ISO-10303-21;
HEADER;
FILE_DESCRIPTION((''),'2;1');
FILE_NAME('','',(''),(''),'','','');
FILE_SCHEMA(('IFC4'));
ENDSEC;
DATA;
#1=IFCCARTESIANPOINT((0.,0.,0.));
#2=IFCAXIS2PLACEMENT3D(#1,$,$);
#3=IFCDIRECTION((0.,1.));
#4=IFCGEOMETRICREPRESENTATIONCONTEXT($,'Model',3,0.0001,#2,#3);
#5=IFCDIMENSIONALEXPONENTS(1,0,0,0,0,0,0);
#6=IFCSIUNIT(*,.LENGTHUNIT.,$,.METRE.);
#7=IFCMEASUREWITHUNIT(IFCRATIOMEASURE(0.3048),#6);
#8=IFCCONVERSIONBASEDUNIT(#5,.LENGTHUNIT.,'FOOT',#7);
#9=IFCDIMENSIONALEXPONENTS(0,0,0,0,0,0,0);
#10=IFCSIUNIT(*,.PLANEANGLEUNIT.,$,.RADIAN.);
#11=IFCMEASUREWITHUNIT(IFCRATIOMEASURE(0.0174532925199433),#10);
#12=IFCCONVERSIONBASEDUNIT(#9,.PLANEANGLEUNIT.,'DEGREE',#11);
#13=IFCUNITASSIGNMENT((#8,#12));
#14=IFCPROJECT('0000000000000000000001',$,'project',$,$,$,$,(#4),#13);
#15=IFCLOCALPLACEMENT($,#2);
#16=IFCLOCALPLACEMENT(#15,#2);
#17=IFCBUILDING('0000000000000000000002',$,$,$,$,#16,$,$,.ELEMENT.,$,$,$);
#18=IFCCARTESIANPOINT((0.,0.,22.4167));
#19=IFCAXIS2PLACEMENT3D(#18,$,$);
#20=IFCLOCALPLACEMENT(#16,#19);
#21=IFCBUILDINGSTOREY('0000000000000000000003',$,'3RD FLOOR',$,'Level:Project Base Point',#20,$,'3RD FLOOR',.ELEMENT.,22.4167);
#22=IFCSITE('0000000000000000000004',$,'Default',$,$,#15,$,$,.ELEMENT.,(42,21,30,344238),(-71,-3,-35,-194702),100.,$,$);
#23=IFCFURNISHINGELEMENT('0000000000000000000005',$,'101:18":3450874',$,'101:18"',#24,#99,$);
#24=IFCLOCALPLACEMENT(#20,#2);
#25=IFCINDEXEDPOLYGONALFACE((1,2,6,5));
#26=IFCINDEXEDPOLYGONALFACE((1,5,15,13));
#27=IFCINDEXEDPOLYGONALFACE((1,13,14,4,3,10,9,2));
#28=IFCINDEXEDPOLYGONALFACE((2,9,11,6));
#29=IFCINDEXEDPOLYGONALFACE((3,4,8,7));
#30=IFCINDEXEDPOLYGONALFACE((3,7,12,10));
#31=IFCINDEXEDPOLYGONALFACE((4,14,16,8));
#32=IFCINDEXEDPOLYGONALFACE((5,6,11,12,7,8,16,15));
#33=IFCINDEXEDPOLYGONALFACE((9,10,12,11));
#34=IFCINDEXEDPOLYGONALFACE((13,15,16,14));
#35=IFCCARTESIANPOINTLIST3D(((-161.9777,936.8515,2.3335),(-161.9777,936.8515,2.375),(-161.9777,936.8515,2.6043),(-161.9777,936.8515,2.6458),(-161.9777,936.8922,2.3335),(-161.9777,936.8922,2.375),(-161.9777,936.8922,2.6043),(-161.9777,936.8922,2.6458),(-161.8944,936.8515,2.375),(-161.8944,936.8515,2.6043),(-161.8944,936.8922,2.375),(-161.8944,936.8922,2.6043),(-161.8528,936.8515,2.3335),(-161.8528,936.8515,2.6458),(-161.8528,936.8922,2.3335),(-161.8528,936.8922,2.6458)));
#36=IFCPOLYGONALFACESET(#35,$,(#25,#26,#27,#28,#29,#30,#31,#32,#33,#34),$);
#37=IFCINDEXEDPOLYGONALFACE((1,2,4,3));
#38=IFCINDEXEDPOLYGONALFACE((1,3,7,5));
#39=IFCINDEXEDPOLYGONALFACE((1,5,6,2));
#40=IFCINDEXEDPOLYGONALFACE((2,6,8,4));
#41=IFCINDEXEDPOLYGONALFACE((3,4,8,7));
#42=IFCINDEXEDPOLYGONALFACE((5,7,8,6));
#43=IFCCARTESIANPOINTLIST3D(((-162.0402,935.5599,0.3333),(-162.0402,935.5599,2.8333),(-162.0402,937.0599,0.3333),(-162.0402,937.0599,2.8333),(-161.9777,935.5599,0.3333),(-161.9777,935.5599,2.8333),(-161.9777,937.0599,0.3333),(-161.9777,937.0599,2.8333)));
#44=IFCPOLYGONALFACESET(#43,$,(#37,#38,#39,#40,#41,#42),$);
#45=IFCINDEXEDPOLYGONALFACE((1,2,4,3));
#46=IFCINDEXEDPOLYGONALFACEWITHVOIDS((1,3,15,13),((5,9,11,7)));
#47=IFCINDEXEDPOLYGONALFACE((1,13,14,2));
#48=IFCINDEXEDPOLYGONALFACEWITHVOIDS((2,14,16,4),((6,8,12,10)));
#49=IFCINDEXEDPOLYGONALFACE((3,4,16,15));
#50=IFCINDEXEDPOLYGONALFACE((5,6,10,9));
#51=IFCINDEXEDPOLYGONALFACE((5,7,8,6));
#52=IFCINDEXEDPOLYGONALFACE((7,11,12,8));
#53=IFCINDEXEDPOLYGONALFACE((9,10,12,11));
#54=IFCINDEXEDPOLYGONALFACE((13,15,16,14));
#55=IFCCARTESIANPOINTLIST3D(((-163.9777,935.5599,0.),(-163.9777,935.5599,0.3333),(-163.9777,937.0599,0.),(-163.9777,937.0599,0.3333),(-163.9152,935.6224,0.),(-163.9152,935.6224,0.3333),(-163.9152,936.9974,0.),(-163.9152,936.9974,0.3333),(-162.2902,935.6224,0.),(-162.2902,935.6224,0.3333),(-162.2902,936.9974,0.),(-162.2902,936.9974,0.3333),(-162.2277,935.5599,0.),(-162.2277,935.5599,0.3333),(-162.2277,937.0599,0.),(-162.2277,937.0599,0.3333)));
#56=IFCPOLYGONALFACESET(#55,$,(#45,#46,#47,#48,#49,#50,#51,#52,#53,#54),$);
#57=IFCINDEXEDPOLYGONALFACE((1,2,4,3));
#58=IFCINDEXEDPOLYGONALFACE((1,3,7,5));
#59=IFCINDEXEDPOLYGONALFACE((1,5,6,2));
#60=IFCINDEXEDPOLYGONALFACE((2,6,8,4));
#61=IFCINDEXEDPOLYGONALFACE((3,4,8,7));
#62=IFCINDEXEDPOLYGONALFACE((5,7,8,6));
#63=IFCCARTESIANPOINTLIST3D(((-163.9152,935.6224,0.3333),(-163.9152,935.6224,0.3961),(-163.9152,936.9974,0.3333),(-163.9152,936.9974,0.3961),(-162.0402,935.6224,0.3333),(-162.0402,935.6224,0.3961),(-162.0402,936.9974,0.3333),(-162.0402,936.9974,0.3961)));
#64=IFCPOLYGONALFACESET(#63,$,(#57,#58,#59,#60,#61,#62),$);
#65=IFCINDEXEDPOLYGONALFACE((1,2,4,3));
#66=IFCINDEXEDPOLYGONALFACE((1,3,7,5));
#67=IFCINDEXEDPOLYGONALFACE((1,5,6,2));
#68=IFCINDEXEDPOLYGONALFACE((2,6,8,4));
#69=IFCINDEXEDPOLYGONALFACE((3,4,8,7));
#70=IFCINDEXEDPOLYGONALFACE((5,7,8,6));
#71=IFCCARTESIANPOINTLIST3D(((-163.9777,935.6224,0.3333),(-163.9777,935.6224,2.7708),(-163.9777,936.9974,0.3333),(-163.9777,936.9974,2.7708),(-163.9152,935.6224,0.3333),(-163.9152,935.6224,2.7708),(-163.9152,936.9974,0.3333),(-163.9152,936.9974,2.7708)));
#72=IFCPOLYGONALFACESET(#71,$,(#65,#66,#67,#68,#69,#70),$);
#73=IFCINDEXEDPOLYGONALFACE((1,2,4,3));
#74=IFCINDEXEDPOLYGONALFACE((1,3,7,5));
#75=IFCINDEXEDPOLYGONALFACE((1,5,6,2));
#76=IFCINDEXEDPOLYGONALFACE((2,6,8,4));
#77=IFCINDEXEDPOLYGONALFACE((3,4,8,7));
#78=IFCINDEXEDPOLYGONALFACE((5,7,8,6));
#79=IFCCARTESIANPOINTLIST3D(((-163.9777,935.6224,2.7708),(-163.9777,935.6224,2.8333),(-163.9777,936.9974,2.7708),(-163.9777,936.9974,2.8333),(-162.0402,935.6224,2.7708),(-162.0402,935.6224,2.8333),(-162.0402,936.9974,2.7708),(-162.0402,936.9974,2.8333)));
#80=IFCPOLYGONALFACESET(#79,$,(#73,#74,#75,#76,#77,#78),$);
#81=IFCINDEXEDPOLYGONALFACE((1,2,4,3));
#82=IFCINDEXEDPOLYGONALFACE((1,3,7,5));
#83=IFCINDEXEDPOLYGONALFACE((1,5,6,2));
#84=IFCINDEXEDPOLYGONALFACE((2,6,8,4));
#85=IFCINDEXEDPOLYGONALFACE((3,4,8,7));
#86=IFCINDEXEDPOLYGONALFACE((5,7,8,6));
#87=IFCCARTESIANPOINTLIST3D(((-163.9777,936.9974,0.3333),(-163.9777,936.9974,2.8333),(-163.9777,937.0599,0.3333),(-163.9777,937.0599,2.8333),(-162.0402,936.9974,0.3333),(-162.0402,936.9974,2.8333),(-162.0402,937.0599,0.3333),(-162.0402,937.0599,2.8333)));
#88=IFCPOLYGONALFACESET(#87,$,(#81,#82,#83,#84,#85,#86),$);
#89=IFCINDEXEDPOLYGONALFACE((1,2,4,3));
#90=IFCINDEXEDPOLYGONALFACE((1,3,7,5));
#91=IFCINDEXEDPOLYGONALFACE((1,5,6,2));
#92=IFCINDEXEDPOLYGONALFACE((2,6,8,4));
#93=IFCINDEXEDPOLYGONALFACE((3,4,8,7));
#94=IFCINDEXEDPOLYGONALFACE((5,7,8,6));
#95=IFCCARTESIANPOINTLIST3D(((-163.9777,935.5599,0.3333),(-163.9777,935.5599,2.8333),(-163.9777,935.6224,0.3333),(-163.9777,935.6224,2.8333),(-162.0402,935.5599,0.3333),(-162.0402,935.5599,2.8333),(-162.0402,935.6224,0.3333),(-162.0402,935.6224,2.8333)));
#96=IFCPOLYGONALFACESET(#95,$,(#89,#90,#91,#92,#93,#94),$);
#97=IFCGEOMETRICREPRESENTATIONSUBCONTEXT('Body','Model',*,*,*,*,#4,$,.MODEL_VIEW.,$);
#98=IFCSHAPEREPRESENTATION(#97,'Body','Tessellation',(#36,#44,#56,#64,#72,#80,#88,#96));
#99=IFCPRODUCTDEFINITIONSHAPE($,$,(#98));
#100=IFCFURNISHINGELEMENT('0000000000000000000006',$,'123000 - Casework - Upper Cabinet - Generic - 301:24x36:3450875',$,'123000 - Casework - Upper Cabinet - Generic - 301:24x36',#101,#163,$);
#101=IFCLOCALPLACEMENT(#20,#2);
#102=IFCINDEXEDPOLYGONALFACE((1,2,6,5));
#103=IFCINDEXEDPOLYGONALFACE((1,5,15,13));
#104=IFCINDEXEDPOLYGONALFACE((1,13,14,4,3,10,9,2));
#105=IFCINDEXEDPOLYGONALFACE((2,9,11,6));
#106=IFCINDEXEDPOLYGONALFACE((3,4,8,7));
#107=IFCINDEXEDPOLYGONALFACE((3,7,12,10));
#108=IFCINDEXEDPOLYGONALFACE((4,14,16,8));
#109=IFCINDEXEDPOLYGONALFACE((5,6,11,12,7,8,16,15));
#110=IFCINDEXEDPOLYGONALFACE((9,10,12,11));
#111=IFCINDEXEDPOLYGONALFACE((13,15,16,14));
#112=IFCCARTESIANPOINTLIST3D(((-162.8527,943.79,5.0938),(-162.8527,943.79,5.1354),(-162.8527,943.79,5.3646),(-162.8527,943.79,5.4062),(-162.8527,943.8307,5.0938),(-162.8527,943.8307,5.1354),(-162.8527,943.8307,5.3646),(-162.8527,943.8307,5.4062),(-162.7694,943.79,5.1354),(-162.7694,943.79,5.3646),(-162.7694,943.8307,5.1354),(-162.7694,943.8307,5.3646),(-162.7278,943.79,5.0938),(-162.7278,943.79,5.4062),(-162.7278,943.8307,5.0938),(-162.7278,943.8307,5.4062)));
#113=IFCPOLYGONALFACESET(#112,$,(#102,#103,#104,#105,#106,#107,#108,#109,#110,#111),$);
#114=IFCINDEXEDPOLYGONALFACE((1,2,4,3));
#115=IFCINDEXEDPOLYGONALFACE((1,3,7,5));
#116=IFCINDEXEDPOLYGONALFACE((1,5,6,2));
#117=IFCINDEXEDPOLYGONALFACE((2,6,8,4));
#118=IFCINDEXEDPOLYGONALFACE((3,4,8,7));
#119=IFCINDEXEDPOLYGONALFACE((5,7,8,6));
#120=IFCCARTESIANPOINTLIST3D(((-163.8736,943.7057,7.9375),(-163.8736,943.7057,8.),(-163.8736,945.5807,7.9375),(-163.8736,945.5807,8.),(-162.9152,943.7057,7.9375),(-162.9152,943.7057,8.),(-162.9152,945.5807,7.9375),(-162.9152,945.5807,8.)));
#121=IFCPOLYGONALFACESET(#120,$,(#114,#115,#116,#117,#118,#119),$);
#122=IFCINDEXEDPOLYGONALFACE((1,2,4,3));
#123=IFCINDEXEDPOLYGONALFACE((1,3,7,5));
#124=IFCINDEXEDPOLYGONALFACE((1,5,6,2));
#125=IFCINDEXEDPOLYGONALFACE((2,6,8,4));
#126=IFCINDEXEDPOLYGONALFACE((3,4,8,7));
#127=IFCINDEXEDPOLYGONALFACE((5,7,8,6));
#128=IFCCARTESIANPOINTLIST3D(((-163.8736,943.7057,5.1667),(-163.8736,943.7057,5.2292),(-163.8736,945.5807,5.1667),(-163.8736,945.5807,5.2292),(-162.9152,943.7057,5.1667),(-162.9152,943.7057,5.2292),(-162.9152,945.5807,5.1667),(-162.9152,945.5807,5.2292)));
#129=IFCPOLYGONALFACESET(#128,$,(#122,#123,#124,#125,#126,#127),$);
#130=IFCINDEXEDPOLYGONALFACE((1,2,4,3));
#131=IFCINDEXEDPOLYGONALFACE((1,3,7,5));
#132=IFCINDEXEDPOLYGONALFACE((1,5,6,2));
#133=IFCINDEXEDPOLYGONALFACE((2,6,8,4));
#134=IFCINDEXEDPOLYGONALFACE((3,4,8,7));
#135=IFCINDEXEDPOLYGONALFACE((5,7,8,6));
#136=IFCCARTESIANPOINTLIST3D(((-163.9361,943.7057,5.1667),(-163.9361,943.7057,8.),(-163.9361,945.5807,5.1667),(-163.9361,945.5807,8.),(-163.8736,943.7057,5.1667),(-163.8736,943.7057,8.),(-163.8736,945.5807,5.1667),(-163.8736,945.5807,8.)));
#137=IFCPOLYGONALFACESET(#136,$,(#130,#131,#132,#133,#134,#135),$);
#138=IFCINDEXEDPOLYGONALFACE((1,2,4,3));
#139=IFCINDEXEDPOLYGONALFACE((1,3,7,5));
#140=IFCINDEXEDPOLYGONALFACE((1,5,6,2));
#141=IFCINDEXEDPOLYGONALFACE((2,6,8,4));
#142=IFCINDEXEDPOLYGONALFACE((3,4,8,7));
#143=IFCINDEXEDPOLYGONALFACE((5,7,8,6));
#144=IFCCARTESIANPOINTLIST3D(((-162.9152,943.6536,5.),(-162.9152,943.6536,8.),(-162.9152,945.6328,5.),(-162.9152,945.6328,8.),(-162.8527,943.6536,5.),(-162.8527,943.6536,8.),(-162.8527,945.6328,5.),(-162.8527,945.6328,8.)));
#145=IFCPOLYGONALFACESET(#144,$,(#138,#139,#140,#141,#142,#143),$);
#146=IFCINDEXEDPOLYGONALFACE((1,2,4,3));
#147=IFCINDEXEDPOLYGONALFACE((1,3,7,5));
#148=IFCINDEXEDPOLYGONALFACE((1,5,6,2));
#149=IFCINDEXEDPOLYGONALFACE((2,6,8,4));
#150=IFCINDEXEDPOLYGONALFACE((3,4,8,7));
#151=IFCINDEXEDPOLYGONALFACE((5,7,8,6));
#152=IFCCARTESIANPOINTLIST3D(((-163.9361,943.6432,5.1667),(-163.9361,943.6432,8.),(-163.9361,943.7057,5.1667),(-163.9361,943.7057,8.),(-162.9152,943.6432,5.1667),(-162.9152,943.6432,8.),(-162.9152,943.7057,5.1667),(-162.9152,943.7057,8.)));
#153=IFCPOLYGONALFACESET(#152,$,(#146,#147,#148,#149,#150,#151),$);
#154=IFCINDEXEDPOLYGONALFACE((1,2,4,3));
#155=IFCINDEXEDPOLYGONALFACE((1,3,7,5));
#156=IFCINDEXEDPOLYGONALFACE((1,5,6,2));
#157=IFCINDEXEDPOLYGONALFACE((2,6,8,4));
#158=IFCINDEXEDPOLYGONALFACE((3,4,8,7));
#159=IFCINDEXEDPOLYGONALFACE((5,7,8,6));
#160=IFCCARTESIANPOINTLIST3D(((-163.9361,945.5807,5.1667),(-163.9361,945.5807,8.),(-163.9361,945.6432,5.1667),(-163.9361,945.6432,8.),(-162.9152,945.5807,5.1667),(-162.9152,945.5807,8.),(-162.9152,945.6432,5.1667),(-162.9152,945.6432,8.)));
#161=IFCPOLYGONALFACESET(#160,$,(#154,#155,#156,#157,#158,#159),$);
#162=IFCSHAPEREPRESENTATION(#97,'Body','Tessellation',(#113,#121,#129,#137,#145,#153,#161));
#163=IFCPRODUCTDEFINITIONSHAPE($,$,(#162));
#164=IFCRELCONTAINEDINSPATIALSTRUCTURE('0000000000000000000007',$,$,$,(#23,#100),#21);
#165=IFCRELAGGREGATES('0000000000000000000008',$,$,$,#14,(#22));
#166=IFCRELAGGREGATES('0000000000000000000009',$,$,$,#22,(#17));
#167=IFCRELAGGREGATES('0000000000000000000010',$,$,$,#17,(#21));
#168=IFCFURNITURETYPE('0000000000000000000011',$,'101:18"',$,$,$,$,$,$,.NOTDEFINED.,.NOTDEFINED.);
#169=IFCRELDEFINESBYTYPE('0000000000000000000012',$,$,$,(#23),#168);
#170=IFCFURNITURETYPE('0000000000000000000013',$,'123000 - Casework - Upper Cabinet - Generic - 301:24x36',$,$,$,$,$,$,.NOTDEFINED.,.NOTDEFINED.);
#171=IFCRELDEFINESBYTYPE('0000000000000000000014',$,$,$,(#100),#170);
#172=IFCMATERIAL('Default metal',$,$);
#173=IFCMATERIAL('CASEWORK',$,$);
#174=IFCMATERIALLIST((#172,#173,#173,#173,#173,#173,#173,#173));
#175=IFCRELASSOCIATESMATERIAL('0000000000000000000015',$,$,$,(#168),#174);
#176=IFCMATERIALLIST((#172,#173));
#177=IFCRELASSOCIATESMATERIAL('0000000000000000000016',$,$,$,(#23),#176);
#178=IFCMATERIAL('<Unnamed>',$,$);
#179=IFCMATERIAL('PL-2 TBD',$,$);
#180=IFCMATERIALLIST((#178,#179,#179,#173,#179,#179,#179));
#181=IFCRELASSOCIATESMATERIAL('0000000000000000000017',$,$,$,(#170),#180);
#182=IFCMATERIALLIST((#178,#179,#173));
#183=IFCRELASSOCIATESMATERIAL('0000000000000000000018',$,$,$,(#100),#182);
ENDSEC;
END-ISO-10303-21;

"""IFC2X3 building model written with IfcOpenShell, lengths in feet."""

from ifc_helpers import new_model, entity, si_unit, converted_unit, direction, frame, frame_2d, origin, origin_2d_with_axis, place, context, subcontext, project, spatial, polyline, rectangle, outline, extrude, source, transform, mapped, material, material_list, type_object, type_shapes, element, save


model = new_model("IFC2X3")

# Units and contexts
model_context = context("Model", 3, precision=0.0001, world=origin(), true_north=direction((0.0, 1.0)))
body_context = subcontext(model_context, "Body", "Model", "MODEL_VIEW")
ifc_project = project(units=[converted_unit("LENGTHUNIT", "FOOT", entity("IfcRatioMeasure", 0.3048), si_unit("LENGTHUNIT", "METRE"), dimensions=[1, 0, 0, 0, 0, 0, 0]), converted_unit("PLANEANGLEUNIT", "DEGREE", entity("IfcRatioMeasure", 0.0174532925199433), si_unit("PLANEANGLEUNIT", "RADIAN"), dimensions=[0, 0, 0, 0, 0, 0, 0])], contexts=[model_context])

# Site, building, storey
site_placement = place(None, origin())
site = spatial("IfcSite", under=ifc_project, at=site_placement, Name="Default", CompositionType="ELEMENT", RefLatitude=(42, 21, 30, 344238), RefLongitude=(-71, -3, -35, -194702), RefElevation=100.0)
building_placement = place(site_placement, origin())
building = spatial("IfcBuilding", under=site, at=building_placement, CompositionType="ELEMENT")
storey_placement = place(building_placement, frame((0.0, 0.0, 22.4167)))
storey = spatial("IfcBuildingStorey", under=building, at=storey_placement, Name="3RD FLOOR", ObjectType="Level:Project Base Point", LongName="3RD FLOOR", CompositionType="ELEMENT", Elevation=22.4167)

# Furnishing elements
ifc_material_1 = material(Name="CASEWORK")
ifc_material_2 = material(Name="<Unnamed>")
ifc_material_3 = material(Name="Default metal")
ifc_material_list_1 = material_list([ifc_material_3, ifc_material_1])
ifc_material_list_2 = material_list([ifc_material_3, ifc_material_1, ifc_material_1, ifc_material_1, ifc_material_1, ifc_material_1, ifc_material_1, ifc_material_1])
furniture_type_1 = type_object("IfcFurnitureType", Name="101:18\"", material=ifc_material_list_2)
shared_shape_1 = source(origin(), body_context, "Body", "SweptSolid", [
    extrude(outline(polyline([(0.1146, -0.0521), (0.1562, -0.0521), (0.1562, 0.0729), (-0.1562, 0.0729), (-0.1562, -0.0521), (-0.1146, -0.0521), (-0.1146, 0.0313), (0.1146, 0.0313), (0.1146, -0.0521)])), frame((0.3531, -2.0521, 2.4896), z_axis=(1.0, 0.0, 0.0), x_axis=(0.0, 0.0, 1.0)), (0.0, 0.0, 1.0), 0.0407),
    extrude(rectangle(XDim=0.0625, YDim=1.5, at=frame_2d((0.0, 0.0), x_axis=(1.0, 0.0))), frame((-0.1885, -1.9688, 0.3333), z_axis=(0.0, 0.0, 1.0), x_axis=(0.0, 1.0, 0.0)), (0.0, 0.0, 1.0), 2.5),
    extrude(outline(polyline([(-0.75, -0.875), (0.75, -0.875), (0.75, 0.875), (-0.75, 0.875), (-0.75, -0.875)]), holes=[polyline([(-0.6875, -0.8125), (-0.6875, 0.8125), (0.6875, 0.8125), (0.6875, -0.8125), (-0.6875, -0.8125)])]), frame((-0.1885, -0.875, 0.0)), (0.0, 0.0, 1.0), 0.3333),
    extrude(rectangle(XDim=1.375, YDim=1.875, at=frame_2d((0.0, 0.0), x_axis=(1.0, 0.0))), frame((-0.1885, -1.0, 0.3333), z_axis=(0.0, 0.0, 1.0), x_axis=(-1.0, 0.0, 0.0)), (0.0, 0.0, 1.0), 0.0627),
    extrude(rectangle(XDim=0.0625, YDim=1.375, at=origin_2d_with_axis()), frame((-0.1885, -0.0312, 0.3333), z_axis=(0.0, 0.0, 1.0), x_axis=(0.0, 1.0, 0.0)), (0.0, 0.0, 1.0), 2.4375),
    extrude(rectangle(XDim=1.375, YDim=1.9375, at=origin_2d_with_axis()), frame((-0.1885, -0.9688, 2.7708), z_axis=(0.0, 0.0, 1.0), x_axis=(-1.0, 0.0, 0.0)), (0.0, 0.0, 1.0), 0.0625),
    extrude(rectangle(XDim=0.0625, YDim=1.9375, at=frame_2d((0.0, 0.0), x_axis=(1.0, 0.0))), frame((0.5302, -0.9687, 0.3333)), (0.0, 0.0, 1.0), 2.5),
    extrude(rectangle(XDim=0.0625, YDim=1.9375, at=frame_2d((0.0, 0.0), x_axis=(1.0, 0.0))), frame((-0.9073, -0.9687, 0.3333)), (0.0, 0.0, 1.0), 2.5),
])
type_shapes(furniture_type_1, [shared_shape_1])
furnishing_1_placement = place(storey_placement, frame((-163.9777, 936.4984, 0.0), z_axis=(0.0, 0.0, 1.0), x_axis=(0.0, 1.0, 0.0)))
element("IfcFurnishingElement", 1, at=furnishing_1_placement, inside=storey, type_object=furniture_type_1, material=ifc_material_list_1, Name="101:18\":3450874", ObjectType="101:18\"", context=body_context, shape_type="MappedRepresentation", body=[
    mapped(shared_shape_1, transform((0.0, 0.0, 0.0), scale=1.0)),
])
ifc_material_4 = material(Name="PL-2 TBD")
ifc_material_list_3 = material_list([ifc_material_2, ifc_material_4, ifc_material_1])
ifc_material_list_4 = material_list([ifc_material_2, ifc_material_4, ifc_material_4, ifc_material_1, ifc_material_4, ifc_material_4, ifc_material_4])
furniture_type_2 = type_object("IfcFurnitureType", Name="123000 - Casework - Upper Cabinet - Generic - 301:24x36", material=ifc_material_list_4)
shared_shape_2 = source(origin(), body_context, "Body", "SweptSolid", [
    extrude(outline(polyline([(0.1146, -0.0521), (0.1562, -0.0521), (0.1562, 0.0729), (-0.1562, 0.0729), (-0.1562, -0.0521), (-0.1146, -0.0521), (-0.1146, 0.0313), (0.1146, 0.0313), (0.1146, -0.0521)])), frame((0.1468, 0.0729, 0.25), z_axis=(1.0, 0.0, 0.0), x_axis=(0.0, 0.0, 1.0)), (0.0, 0.0, 1.0), 0.0407),
    extrude(rectangle(XDim=1.875, YDim=0.9583, at=frame_2d((0.0, 0.0), x_axis=(1.0, 0.0))), frame((1.0, 0.6666, 2.9375), z_axis=(0.0, 0.0, 1.0), x_axis=(-1.0, 0.0, 0.0)), (0.0, 0.0, 1.0), 0.0625),
    extrude(rectangle(XDim=1.875, YDim=0.9583, at=frame_2d((0.0, 0.0), x_axis=(1.0, 0.0))), frame((1.0, 0.6666, 0.1667), z_axis=(0.0, 0.0, 1.0), x_axis=(-1.0, 0.0, 0.0)), (0.0, 0.0, 1.0), 0.0625),
    extrude(rectangle(XDim=0.0625, YDim=1.875, at=origin_2d_with_axis()), frame((1.0, 1.177, 0.1667), z_axis=(0.0, 0.0, 1.0), x_axis=(0.0, 1.0, 0.0)), (0.0, 0.0, 1.0), 2.8333),
    extrude(rectangle(XDim=0.0625, YDim=1.9792, at=frame_2d((0.0, 0.0), x_axis=(1.0, 0.0))), frame((1.0, 0.1562, 0.0), z_axis=(0.0, 0.0, 1.0), x_axis=(0.0, -1.0, 0.0)), (0.0, 0.0, 1.0), 3.0),
    extrude(rectangle(XDim=0.0625, YDim=1.0208, at=origin_2d_with_axis()), frame((0.0312, 0.6979, 0.1667), z_axis=(0.0, 0.0, 1.0), x_axis=(-1.0, 0.0, 0.0)), (0.0, 0.0, 1.0), 2.8333),
    extrude(rectangle(XDim=0.0625, YDim=1.0208, at=frame_2d((0.0, 0.0), x_axis=(1.0, 0.0))), frame((1.9688, 0.6979, 0.1667), z_axis=(0.0, 0.0, 1.0), x_axis=(-1.0, 0.0, 0.0)), (0.0, 0.0, 1.0), 2.8333),
])
type_shapes(furniture_type_2, [shared_shape_2])
furnishing_2_placement = place(storey_placement, frame((-162.7278, 943.6432, 5.0), z_axis=(0.0, 0.0, 1.0), x_axis=(0.0, 1.0, 0.0)))
element("IfcFurnishingElement", 2, at=furnishing_2_placement, inside=storey, type_object=furniture_type_2, material=ifc_material_list_3, Name="123000 - Casework - Upper Cabinet - Generic - 301:24x36:3450875", ObjectType="123000 - Casework - Upper Cabinet - Generic - 301:24x36", context=body_context, shape_type="MappedRepresentation", body=[
    mapped(shared_shape_2, transform((0.0, 0.0, 0.0), scale=1.0)),
])

save(model, "model.ifc")
